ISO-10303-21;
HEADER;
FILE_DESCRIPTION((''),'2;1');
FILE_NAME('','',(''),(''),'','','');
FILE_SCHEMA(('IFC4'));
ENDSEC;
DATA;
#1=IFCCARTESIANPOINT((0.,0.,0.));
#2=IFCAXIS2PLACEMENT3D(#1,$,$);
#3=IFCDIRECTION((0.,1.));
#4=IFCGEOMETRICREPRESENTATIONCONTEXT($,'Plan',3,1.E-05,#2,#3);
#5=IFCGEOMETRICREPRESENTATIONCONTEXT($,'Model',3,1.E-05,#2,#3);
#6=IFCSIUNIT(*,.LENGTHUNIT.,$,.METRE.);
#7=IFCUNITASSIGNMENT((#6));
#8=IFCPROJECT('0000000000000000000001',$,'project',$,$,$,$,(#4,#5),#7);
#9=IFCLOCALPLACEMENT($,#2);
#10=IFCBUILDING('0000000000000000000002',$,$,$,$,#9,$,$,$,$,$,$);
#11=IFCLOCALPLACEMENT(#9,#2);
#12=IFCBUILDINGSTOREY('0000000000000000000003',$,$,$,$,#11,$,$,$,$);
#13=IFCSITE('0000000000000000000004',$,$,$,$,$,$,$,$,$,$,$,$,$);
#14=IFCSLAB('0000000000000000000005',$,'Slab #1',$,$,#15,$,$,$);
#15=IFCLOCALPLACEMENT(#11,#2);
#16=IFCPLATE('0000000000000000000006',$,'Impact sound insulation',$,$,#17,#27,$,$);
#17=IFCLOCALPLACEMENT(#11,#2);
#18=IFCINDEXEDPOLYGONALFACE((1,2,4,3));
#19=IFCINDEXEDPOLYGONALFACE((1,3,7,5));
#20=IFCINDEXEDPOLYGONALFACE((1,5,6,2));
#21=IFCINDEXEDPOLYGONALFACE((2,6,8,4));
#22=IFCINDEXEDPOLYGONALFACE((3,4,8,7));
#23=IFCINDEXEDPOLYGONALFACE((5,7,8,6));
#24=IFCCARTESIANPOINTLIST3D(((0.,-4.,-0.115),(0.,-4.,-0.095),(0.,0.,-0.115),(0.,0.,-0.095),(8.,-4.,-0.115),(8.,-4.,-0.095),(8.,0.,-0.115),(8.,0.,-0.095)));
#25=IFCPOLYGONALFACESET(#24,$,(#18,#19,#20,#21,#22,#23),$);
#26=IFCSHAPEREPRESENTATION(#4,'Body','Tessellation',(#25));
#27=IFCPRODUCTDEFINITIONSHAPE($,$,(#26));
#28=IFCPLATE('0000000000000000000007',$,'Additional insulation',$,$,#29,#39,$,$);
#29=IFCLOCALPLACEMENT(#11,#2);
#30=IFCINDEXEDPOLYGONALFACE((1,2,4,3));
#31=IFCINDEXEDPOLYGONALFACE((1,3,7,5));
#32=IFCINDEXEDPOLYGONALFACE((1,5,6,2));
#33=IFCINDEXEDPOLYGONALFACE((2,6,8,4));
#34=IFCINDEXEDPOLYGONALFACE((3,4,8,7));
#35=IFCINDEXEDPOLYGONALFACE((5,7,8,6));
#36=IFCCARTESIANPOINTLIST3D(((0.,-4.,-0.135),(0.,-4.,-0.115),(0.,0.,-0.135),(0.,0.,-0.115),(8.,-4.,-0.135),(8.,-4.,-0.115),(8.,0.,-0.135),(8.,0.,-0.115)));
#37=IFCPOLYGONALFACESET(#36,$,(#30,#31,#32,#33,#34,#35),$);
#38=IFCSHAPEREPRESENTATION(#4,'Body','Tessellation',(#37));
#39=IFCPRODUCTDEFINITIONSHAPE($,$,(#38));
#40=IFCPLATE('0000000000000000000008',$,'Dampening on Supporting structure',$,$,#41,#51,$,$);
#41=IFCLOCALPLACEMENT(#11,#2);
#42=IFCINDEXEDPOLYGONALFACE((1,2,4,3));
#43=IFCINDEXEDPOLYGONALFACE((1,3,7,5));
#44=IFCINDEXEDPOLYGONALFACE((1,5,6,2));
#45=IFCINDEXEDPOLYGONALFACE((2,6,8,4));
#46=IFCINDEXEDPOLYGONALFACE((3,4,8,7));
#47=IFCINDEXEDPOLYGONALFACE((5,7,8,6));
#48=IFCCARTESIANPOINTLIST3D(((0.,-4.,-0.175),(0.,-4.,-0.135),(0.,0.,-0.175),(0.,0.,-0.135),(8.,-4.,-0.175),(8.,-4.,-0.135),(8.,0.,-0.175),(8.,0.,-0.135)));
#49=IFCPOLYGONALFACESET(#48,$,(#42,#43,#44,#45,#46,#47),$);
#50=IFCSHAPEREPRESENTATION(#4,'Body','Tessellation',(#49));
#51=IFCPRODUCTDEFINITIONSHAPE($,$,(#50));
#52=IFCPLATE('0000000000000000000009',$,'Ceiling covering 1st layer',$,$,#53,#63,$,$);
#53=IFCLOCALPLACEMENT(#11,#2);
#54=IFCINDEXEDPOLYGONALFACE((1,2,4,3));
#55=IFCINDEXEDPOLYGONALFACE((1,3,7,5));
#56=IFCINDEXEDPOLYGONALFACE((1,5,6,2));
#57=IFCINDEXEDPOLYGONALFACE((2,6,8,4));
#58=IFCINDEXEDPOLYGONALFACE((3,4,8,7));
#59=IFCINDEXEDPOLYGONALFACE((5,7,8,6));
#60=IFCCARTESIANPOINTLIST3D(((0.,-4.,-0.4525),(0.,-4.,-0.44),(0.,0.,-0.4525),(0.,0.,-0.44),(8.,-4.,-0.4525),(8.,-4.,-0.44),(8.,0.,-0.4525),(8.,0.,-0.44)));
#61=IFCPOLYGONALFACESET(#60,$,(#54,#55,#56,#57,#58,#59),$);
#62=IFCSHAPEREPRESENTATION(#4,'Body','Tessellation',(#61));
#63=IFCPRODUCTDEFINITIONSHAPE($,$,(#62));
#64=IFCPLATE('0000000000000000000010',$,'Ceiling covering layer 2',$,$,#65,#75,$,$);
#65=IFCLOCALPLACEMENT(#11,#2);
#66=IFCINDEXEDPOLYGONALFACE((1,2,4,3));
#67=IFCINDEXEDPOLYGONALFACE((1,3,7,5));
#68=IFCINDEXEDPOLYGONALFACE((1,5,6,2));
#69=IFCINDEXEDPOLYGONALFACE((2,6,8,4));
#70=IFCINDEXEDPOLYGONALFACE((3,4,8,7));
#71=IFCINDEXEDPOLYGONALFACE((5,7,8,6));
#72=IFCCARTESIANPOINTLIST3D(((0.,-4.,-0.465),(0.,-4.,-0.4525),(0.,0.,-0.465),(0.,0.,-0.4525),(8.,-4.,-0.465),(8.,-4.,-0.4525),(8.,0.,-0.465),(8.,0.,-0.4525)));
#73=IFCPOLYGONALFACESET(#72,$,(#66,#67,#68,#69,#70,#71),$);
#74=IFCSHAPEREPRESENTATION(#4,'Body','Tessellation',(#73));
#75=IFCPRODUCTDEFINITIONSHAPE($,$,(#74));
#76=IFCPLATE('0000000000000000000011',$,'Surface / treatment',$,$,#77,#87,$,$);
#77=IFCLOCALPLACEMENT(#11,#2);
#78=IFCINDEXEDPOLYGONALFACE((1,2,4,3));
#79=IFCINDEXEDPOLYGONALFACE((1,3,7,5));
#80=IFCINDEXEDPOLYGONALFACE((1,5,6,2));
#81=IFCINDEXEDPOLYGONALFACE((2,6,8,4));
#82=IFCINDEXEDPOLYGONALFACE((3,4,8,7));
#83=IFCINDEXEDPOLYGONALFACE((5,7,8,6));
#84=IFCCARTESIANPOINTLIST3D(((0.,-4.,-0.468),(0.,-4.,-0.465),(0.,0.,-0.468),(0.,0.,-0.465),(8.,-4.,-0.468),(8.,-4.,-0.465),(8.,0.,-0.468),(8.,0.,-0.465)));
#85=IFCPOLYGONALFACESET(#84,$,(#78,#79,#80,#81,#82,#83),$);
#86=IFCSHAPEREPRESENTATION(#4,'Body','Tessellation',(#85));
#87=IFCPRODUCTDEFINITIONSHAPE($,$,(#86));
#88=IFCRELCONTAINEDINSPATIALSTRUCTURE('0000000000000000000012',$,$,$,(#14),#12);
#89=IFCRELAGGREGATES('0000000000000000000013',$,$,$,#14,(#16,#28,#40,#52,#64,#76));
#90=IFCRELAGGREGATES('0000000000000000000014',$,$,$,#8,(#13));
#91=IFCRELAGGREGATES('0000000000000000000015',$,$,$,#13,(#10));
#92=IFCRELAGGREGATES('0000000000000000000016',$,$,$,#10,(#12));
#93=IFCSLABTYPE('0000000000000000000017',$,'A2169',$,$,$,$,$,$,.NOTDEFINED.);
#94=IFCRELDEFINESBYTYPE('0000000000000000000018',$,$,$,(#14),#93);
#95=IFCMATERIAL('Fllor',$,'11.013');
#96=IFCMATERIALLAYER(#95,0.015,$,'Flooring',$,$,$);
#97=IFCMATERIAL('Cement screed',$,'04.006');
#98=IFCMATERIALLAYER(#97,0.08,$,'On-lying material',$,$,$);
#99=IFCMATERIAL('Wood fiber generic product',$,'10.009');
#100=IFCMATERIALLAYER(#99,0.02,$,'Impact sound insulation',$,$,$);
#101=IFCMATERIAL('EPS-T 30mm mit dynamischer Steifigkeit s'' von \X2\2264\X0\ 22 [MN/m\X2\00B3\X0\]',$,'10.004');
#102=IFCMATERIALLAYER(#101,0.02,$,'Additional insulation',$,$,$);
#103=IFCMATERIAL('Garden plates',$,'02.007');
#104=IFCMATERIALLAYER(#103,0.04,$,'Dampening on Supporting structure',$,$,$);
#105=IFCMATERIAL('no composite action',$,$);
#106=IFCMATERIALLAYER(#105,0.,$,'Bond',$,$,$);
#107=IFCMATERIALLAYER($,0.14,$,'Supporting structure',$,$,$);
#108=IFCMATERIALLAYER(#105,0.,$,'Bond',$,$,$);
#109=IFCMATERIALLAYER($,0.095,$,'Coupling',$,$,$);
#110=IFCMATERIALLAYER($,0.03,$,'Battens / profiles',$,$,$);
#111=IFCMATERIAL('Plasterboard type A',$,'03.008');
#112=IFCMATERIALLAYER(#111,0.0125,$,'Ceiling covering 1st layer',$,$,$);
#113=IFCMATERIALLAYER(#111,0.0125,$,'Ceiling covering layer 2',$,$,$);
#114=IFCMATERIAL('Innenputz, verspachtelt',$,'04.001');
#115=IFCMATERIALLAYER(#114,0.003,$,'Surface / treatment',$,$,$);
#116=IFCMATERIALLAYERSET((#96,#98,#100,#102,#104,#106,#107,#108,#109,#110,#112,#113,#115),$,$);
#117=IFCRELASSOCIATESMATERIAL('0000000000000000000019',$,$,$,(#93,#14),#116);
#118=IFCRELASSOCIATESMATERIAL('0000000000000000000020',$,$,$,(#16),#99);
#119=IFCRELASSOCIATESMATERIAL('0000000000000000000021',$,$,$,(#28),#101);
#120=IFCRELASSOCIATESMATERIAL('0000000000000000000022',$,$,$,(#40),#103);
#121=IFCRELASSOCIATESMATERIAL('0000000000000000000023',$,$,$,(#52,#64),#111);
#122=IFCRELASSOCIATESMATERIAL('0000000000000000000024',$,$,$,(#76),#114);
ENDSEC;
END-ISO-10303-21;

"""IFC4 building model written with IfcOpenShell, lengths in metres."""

from ifc_helpers import new_model, si_unit, direction, frame, frame_2d, origin, place, context, project, spatial, rectangle, extrude, material, layer, layer_set, type_object, element, aggregate, save


model = new_model("IFC4")

# Units and contexts
plan_context = context("Plan", 3, precision=1e-05, world=origin(), true_north=direction((0.0, 1.0)))
model_context = context("Model", 3, precision=1e-05, world=origin(), true_north=direction((0.0, 1.0)))
ifc_project = project(units=[si_unit("LENGTHUNIT", "METRE")], contexts=[plan_context, model_context])

# Site, building, storey
site = spatial("IfcSite", under=ifc_project)
building_placement = place(None, origin())
building = spatial("IfcBuilding", under=site, at=building_placement)
storey_placement = place(building_placement, origin())
storey = spatial("IfcBuildingStorey", under=building, at=storey_placement)

# Slab, plates
ifc_material_1 = material(Name="Fllor", Category="11.013")
ifc_layer_1 = layer(ifc_material_1, 0.015, Name="Flooring")
ifc_material_2 = material(Name="Cement screed", Category="04.006")
ifc_layer_2 = layer(ifc_material_2, 0.08, Name="On-lying material")
ifc_material_3 = material(Name="Wood fiber generic product", Category="10.009")
ifc_layer_3 = layer(ifc_material_3, 0.02, Name="Impact sound insulation")
ifc_material_4 = material(Name="EPS-T 30mm mit dynamischer Steifigkeit s' von ≤ 22 [MN/m³]", Category="10.004")
ifc_layer_4 = layer(ifc_material_4, 0.02, Name="Additional insulation")
ifc_material_5 = material(Name="Garden plates", Category="02.007")
ifc_layer_5 = layer(ifc_material_5, 0.04, Name="Dampening on Supporting structure")
ifc_material_6 = material(Name="no composite action")
ifc_layer_6 = layer(ifc_material_6, 0.0, Name="Bond")
ifc_layer_7 = layer(None, 0.14, Name="Supporting structure")
ifc_layer_8 = layer(ifc_material_6, 0.0, Name="Bond")
ifc_layer_9 = layer(None, 0.095, Name="Coupling")
ifc_layer_10 = layer(None, 0.03, Name="Battens / profiles")
ifc_material_7 = material(Name="Plasterboard type A", Category="03.008")
ifc_layer_11 = layer(ifc_material_7, 0.0125, Name="Ceiling covering 1st layer")
ifc_layer_12 = layer(ifc_material_7, 0.0125, Name="Ceiling covering layer 2")
ifc_material_8 = material(Name="Innenputz, verspachtelt", Category="04.001")
ifc_layer_13 = layer(ifc_material_8, 0.003, Name="Surface / treatment")
ifc_layer_set = layer_set([ifc_layer_1, ifc_layer_2, ifc_layer_3, ifc_layer_4, ifc_layer_5, ifc_layer_6, ifc_layer_7, ifc_layer_8, ifc_layer_9, ifc_layer_10, ifc_layer_11, ifc_layer_12, ifc_layer_13])
slab_type = type_object("IfcSlabType", Name="A2169", PredefinedType="NOTDEFINED", material=ifc_layer_set)
slab_placement = place(None, frame((0.0, 0.0, 0.0), z_axis=(0.0, 0.0, -1.0), x_axis=(1.0, 0.0, 0.0)))
slab = element("IfcSlab", 1, at=slab_placement, inside=storey, type_object=slab_type, material=ifc_layer_set, Name="Slab #1")
plate_1_placement = place(slab_placement, origin())
plate_1 = element("IfcPlate", 2, at=plate_1_placement, material=ifc_material_3, Name="Impact sound insulation", context=plan_context, shape_type="SweptSolid", body=[
    extrude(rectangle(XDim=8.0, YDim=4.0, at=frame_2d((4.0, 2.0), x_axis=(1.0, 0.0))), frame((0.0, 0.0, 0.095), z_axis=(0.0, 0.0, 1.0), x_axis=(1.0, 0.0, 0.0)), (0.0, 0.0, 1.0), 0.02),
])
plate_2_placement = place(slab_placement, origin())
plate_2 = element("IfcPlate", 3, at=plate_2_placement, material=ifc_material_4, Name="Additional insulation", context=plan_context, shape_type="SweptSolid", body=[
    extrude(rectangle(XDim=8.0, YDim=4.0, at=frame_2d((4.0, 2.0), x_axis=(1.0, 0.0))), frame((0.0, 0.0, 0.115), z_axis=(0.0, 0.0, 1.0), x_axis=(1.0, 0.0, 0.0)), (0.0, 0.0, 1.0), 0.02),
])
plate_3_placement = place(slab_placement, origin())
plate_3 = element("IfcPlate", 4, at=plate_3_placement, material=ifc_material_5, Name="Dampening on Supporting structure", context=plan_context, shape_type="SweptSolid", body=[
    extrude(rectangle(XDim=8.0, YDim=4.0, at=frame_2d((4.0, 2.0), x_axis=(1.0, 0.0))), frame((0.0, 0.0, 0.135), z_axis=(0.0, 0.0, 1.0), x_axis=(1.0, 0.0, 0.0)), (0.0, 0.0, 1.0), 0.04),
])
plate_4_placement = place(slab_placement, origin())
plate_4 = element("IfcPlate", 5, at=plate_4_placement, material=ifc_material_7, Name="Ceiling covering 1st layer", context=plan_context, shape_type="SweptSolid", body=[
    extrude(rectangle(XDim=8.0, YDim=4.0, at=frame_2d((4.0, 2.0), x_axis=(1.0, 0.0))), frame((0.0, 0.0, 0.44), z_axis=(0.0, 0.0, 1.0), x_axis=(1.0, 0.0, 0.0)), (0.0, 0.0, 1.0), 0.0125),
])
plate_5_placement = place(slab_placement, origin())
plate_5 = element("IfcPlate", 6, at=plate_5_placement, material=ifc_material_7, Name="Ceiling covering layer 2", context=plan_context, shape_type="SweptSolid", body=[
    extrude(rectangle(XDim=8.0, YDim=4.0, at=frame_2d((4.0, 2.0), x_axis=(1.0, 0.0))), frame((0.0, 0.0, 0.4525), z_axis=(0.0, 0.0, 1.0), x_axis=(1.0, 0.0, 0.0)), (0.0, 0.0, 1.0), 0.0125),
])
plate_6_placement = place(slab_placement, origin())
plate_6 = element("IfcPlate", 7, at=plate_6_placement, material=ifc_material_8, Name="Surface / treatment", context=plan_context, shape_type="SweptSolid", body=[
    extrude(rectangle(XDim=8.0, YDim=4.0, at=frame_2d((4.0, 2.0), x_axis=(1.0, 0.0))), frame((0.0, 0.0, 0.465), z_axis=(0.0, 0.0, 1.0), x_axis=(1.0, 0.0, 0.0)), (0.0, 0.0, 1.0), 0.003),
])
aggregate(slab, [plate_1, plate_2, plate_3, plate_4, plate_5, plate_6])

save(model, "model.ifc")
